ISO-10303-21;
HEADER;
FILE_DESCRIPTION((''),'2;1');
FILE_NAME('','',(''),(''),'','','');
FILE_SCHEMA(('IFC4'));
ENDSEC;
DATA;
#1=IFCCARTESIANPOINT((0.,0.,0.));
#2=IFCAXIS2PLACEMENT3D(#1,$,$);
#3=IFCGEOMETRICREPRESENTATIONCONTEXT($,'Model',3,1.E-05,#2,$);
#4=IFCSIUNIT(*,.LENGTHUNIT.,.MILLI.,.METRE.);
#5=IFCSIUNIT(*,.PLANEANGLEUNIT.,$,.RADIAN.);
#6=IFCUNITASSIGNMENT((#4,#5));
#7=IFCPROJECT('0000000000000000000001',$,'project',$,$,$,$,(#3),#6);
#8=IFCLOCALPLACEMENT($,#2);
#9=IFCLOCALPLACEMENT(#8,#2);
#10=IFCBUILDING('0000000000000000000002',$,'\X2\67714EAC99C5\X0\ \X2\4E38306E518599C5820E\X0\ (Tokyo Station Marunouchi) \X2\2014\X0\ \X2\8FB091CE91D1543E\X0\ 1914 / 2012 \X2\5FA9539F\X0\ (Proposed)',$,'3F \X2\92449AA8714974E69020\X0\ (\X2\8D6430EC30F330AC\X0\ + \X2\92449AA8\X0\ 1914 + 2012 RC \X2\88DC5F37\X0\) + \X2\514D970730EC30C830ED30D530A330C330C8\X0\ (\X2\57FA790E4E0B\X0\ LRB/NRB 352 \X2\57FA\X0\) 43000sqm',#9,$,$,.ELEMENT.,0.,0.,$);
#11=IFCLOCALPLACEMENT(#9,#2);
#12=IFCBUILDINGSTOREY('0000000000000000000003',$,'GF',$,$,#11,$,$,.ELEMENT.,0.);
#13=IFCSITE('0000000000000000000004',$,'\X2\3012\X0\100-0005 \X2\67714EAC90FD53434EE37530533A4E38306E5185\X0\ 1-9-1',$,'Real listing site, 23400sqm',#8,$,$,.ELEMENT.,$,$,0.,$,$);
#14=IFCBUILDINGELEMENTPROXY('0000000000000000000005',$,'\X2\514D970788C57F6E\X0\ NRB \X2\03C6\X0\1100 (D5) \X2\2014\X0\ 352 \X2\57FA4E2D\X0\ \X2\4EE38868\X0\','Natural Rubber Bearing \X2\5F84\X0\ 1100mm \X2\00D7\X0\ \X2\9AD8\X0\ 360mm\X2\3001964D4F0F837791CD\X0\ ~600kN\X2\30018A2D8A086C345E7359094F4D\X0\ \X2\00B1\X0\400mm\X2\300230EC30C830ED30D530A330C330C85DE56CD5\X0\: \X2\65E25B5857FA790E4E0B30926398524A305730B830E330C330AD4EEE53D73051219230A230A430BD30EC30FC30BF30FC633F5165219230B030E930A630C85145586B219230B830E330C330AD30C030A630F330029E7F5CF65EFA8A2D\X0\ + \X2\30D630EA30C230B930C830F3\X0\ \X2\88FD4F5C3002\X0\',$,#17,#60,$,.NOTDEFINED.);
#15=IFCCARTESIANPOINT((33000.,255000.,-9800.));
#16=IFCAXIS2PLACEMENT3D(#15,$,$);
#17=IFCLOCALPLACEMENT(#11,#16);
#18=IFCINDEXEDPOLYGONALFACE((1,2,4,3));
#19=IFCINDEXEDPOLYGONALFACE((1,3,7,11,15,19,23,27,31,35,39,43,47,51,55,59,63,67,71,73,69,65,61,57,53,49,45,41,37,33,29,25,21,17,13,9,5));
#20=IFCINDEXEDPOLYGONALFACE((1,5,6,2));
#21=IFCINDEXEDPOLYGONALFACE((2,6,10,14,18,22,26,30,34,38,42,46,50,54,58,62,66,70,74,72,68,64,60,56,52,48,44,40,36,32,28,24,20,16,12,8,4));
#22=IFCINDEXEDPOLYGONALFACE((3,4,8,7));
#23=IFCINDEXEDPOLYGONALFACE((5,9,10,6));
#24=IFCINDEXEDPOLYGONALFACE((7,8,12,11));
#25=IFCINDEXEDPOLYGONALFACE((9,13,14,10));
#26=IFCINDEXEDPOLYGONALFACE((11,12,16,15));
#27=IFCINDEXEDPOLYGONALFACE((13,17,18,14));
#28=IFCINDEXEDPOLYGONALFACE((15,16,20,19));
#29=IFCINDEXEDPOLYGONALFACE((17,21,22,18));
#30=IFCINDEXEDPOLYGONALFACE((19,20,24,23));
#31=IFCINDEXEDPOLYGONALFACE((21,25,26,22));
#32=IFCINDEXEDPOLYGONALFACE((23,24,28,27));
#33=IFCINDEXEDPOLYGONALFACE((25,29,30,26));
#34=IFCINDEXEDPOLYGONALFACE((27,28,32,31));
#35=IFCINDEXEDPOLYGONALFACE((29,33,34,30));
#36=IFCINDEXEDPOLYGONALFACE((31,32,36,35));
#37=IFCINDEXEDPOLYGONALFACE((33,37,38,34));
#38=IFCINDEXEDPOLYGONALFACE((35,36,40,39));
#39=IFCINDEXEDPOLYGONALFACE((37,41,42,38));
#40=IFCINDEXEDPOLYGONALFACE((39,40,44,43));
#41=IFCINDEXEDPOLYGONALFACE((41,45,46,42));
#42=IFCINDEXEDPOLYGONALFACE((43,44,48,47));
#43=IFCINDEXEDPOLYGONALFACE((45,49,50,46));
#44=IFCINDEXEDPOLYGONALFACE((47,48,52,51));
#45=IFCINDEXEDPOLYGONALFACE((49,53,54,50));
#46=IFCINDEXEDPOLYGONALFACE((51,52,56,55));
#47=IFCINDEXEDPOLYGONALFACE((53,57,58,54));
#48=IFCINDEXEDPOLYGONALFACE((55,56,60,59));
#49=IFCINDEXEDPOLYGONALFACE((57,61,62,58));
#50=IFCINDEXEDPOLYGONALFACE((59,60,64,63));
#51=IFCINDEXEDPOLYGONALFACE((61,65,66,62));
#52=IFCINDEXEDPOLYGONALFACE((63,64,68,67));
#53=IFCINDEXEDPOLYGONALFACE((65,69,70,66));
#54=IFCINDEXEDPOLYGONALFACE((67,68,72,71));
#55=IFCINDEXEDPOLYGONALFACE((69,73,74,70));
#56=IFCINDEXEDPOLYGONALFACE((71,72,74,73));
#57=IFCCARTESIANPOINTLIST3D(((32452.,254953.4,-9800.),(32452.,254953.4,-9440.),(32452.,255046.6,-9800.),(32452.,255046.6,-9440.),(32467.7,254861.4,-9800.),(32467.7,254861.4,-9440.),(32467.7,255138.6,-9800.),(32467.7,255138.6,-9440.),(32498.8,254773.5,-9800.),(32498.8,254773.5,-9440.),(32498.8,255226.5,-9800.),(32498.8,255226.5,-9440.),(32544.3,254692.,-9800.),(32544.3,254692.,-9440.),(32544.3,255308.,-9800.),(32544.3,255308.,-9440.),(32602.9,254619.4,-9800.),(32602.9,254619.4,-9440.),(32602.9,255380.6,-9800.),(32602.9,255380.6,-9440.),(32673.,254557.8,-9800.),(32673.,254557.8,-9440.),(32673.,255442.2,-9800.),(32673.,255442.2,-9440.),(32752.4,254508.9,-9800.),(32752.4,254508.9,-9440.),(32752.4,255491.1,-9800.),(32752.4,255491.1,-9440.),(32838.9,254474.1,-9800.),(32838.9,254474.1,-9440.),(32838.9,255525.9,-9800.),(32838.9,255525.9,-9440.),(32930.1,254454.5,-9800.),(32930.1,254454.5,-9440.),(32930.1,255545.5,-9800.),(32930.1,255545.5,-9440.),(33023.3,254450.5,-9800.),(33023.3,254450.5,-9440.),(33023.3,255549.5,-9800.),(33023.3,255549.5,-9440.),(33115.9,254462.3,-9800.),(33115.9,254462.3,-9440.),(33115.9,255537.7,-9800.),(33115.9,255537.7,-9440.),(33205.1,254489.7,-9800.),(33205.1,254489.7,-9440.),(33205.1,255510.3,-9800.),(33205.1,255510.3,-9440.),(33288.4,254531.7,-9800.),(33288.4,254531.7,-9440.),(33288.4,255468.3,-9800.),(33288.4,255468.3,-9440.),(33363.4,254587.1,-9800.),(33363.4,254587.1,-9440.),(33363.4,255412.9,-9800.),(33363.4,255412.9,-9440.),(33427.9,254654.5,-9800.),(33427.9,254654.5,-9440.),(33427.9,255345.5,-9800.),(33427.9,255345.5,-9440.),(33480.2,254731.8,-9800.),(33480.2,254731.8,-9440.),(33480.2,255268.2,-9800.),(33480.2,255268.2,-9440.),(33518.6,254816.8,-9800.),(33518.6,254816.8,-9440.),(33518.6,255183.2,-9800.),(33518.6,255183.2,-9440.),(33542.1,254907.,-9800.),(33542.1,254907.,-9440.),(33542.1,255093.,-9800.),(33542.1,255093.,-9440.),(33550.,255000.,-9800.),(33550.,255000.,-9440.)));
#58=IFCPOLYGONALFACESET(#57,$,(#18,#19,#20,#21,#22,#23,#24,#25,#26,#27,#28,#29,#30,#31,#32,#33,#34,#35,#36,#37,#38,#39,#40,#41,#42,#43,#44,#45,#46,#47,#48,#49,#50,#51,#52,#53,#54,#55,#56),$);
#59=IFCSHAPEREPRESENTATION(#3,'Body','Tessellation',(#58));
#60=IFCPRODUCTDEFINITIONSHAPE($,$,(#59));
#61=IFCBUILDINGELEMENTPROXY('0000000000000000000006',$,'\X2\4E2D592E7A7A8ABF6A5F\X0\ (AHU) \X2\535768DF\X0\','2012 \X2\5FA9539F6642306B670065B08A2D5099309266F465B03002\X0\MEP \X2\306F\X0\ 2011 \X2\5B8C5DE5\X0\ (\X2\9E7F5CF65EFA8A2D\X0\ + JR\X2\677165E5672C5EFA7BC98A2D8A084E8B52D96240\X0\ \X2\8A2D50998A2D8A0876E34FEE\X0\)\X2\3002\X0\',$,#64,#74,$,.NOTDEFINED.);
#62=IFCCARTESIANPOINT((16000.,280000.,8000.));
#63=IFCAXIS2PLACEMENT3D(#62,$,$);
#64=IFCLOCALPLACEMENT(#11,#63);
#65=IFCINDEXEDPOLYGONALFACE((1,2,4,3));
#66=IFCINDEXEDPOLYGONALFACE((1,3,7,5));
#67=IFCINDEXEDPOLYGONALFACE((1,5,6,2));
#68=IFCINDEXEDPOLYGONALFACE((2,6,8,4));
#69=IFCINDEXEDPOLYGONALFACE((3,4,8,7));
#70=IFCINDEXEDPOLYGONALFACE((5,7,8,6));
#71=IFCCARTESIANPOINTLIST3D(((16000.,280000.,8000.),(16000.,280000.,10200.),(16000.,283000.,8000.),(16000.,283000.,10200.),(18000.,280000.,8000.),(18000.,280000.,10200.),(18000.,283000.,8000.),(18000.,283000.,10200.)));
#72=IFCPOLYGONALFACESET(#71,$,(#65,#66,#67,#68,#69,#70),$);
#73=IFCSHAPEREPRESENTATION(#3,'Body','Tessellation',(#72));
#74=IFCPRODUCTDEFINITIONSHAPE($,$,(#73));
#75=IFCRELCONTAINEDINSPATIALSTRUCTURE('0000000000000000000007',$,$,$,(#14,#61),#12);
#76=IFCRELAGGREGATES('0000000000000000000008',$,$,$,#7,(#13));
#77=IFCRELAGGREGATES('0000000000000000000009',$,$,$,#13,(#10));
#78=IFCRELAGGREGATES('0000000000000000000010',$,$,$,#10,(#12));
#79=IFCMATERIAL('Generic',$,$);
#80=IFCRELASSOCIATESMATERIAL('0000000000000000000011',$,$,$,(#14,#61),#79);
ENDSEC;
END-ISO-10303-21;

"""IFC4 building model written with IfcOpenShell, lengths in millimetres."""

from ifc_helpers import new_model, si_unit, frame, frame_2d, origin, origin_2d, place, context, project, spatial, rectangle, circle, extrude, material, element, save


model = new_model("IFC4")

# Units and contexts
model_context = context("Model", 3, precision=1e-05, world=origin())
ifc_project = project(units=[si_unit("LENGTHUNIT", "METRE", prefix="MILLI"), si_unit("PLANEANGLEUNIT", "RADIAN")], contexts=[model_context])

# Site, building, storey
site_placement = place(None, origin())
site = spatial("IfcSite", under=ifc_project, at=site_placement, Name="〒100-0005 東京都千代田区丸の内 1-9-1", ObjectType="Real listing site, 23400sqm", CompositionType="ELEMENT", RefElevation=0.0)
building_placement = place(site_placement, origin())
building = spatial("IfcBuilding", under=site, at=building_placement, Name="東京駅 丸の内駅舎 (Tokyo Station Marunouchi) — 辰野金吾 1914 / 2012 復原 (Proposed)", ObjectType="3F 鉄骨煉瓦造 (赤レンガ + 鉄骨 1914 + 2012 RC 補強) + 免震レトロフィット (基礎下 LRB/NRB 352 基) 43000sqm", CompositionType="ELEMENT", ElevationOfRefHeight=0.0, ElevationOfTerrain=0.0)
storey_placement = place(building_placement, origin())
storey = spatial("IfcBuildingStorey", under=building, at=storey_placement, Name="GF", CompositionType="ELEMENT", Elevation=0.0)

# Building element proxies
ifc_material_1 = material(Name="Generic")
proxy_1_placement = place(storey_placement, frame((33000.0, 255000.0, -9800.0)))
element("IfcBuildingElementProxy", 1, at=proxy_1_placement, inside=storey, material=ifc_material_1, Name="免震装置 NRB φ1100 (D5) — 352 基中 代表", Description="Natural Rubber Bearing 径 1100mm × 高 360mm、降伏荷重 ~600kN、設計水平変位 ±400mm。レトロフィット工法: 既存基礎下を掘削しジャッキ仮受け→アイソレーター挿入→グラウト充填→ジャッキダウン。鹿島建設 + ブリヂストン 製作。", PredefinedType="NOTDEFINED", context=model_context, shape_type="SweptSolid", body=[
    extrude(circle(Radius=550.0, at=origin_2d()), frame((33000.0, 255000.0, -9800.0)), (0.0, 0.0, 1.0), 360.0),
])
proxy_2_placement = place(storey_placement, frame((16000.0, 280000.0, 8000.0)))
element("IfcBuildingElementProxy", 2, at=proxy_2_placement, inside=storey, material=ifc_material_1, Name="中央空調機 (AHU) 南棟", Description="2012 復原時に最新設備を更新。MEP は 2011 完工 (鹿島建設 + JR東日本建築設計事務所 設備設計監修)。", PredefinedType="NOTDEFINED", context=model_context, shape_type="SweptSolid", body=[
    extrude(rectangle(XDim=2000.0, YDim=3000.0, at=frame_2d((1000.0, 1500.0))), frame((16000.0, 280000.0, 8000.0)), (0.0, 0.0, 1.0), 2200.0),
])

save(model, "model.ifc")
